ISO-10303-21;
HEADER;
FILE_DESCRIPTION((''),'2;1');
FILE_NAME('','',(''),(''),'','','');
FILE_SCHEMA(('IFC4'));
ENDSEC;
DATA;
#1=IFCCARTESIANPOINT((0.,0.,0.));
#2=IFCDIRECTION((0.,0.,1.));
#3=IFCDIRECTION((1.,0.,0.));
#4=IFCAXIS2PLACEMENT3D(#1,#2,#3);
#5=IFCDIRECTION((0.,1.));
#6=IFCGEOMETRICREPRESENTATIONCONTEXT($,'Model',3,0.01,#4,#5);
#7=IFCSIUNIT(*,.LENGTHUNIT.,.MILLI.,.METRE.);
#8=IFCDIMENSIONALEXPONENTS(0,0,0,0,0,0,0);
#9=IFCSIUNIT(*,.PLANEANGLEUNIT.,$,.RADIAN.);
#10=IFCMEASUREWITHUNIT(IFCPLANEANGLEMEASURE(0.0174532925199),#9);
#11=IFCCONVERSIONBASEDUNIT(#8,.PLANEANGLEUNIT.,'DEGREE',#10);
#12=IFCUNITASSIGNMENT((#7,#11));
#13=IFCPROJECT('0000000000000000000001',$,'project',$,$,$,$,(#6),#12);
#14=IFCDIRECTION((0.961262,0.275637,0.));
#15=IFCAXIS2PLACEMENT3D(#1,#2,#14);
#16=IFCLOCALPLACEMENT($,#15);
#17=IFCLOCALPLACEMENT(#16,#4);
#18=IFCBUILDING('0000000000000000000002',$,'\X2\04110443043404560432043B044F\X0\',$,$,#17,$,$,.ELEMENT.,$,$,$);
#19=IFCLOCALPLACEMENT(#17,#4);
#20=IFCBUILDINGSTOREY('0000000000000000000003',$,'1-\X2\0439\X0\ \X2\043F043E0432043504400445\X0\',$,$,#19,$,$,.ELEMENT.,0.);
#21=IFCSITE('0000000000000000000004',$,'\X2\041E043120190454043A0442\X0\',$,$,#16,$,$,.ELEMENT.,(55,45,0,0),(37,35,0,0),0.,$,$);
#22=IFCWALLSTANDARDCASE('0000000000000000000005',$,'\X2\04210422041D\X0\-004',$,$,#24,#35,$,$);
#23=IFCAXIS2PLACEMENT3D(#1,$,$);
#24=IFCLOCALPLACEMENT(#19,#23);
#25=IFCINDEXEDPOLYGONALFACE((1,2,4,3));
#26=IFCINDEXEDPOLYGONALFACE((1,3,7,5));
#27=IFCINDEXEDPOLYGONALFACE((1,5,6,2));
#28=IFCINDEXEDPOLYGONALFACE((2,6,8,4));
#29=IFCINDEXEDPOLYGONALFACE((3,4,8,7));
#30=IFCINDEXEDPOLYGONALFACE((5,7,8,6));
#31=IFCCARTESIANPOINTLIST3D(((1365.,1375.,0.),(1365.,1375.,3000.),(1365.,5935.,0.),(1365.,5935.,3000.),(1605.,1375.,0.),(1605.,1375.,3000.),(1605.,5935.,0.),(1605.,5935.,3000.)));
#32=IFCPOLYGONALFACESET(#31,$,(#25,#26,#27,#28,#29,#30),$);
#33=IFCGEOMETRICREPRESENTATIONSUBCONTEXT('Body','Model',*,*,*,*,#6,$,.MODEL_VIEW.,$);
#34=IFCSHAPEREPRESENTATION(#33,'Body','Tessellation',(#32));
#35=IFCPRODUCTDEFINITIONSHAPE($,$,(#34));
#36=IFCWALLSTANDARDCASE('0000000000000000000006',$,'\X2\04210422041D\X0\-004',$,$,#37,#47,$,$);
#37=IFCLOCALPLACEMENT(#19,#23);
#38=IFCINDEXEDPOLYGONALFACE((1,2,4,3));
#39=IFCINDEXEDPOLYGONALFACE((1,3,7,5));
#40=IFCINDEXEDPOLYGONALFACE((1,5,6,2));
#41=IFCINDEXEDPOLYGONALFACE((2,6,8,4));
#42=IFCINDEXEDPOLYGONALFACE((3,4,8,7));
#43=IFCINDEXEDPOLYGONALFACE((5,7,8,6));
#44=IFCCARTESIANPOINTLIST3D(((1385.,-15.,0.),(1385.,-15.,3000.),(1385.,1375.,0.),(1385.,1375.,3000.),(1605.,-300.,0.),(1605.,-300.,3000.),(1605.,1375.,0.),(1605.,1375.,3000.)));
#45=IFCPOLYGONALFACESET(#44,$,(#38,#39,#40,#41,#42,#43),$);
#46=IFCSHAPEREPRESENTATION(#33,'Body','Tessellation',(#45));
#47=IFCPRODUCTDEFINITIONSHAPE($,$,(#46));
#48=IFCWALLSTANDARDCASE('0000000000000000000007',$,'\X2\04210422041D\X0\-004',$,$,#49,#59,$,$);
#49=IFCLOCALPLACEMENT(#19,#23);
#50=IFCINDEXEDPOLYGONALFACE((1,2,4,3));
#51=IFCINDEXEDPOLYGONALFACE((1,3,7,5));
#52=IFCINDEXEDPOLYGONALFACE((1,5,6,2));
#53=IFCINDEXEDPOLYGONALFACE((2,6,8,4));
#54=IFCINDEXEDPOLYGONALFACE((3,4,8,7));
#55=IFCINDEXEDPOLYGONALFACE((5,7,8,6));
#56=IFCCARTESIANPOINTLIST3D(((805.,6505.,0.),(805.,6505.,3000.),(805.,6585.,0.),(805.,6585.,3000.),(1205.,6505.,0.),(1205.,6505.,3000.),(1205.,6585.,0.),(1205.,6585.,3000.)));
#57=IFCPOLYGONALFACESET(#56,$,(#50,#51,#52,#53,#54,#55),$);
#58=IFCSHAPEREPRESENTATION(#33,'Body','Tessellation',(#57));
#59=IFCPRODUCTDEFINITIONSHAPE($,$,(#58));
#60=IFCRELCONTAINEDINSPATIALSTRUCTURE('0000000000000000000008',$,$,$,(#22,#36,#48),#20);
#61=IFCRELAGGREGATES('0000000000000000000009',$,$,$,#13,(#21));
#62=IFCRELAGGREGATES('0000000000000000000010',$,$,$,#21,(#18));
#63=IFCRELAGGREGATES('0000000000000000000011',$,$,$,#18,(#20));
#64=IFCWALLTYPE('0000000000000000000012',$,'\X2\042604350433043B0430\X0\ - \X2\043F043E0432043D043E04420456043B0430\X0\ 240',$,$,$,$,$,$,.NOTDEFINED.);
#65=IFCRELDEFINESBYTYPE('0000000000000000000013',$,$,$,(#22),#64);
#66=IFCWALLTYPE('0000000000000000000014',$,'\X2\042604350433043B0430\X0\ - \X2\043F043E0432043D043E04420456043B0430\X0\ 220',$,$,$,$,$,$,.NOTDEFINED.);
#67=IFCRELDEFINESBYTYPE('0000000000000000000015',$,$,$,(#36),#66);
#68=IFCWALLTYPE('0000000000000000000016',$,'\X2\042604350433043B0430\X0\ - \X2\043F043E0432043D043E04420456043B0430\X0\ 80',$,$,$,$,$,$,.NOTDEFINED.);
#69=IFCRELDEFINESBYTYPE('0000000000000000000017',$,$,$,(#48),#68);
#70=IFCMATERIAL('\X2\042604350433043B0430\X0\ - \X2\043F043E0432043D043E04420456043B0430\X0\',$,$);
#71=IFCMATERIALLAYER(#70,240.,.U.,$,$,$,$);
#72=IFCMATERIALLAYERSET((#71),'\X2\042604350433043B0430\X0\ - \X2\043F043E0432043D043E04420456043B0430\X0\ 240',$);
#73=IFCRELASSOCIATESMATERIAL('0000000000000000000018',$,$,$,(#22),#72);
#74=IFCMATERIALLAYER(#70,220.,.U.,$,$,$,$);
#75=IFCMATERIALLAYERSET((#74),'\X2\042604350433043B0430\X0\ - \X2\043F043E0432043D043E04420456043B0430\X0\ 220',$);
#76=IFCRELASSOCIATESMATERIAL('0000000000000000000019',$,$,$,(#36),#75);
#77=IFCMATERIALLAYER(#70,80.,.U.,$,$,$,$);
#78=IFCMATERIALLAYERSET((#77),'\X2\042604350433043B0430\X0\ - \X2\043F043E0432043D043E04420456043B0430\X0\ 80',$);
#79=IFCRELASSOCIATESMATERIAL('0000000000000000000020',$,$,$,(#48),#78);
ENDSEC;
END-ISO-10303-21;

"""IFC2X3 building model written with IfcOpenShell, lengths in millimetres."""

from ifc_helpers import new_model, entity, si_unit, converted_unit, direction, frame, origin_with_axes, place, context, subcontext, project, spatial, polyline, outline, extrude, material, layer, layer_set, layer_usage, type_object, element, save


model = new_model("IFC2X3")

# Units and contexts
model_context = context("Model", 3, precision=0.01, world=origin_with_axes(), true_north=direction((0.0, 1.0)))
body_context = subcontext(model_context, "Body", "Model", "MODEL_VIEW")
ifc_project = project(units=[si_unit("LENGTHUNIT", "METRE", prefix="MILLI"), converted_unit("PLANEANGLEUNIT", "DEGREE", entity("IfcPlaneAngleMeasure", 0.0174532925199), si_unit("PLANEANGLEUNIT", "RADIAN"), dimensions=[0, 0, 0, 0, 0, 0, 0])], contexts=[model_context])

# Site, building, storey
site_placement = place(None, frame((0.0, 0.0, 0.0), z_axis=(0.0, 0.0, 1.0), x_axis=(0.961262, 0.275637, 0.0)))
site = spatial("IfcSite", under=ifc_project, at=site_placement, Name="Об’єкт", CompositionType="ELEMENT", RefLatitude=(55, 45, 0, 0), RefLongitude=(37, 35, 0, 0), RefElevation=0.0)
building_placement = place(site_placement, origin_with_axes())
building = spatial("IfcBuilding", under=site, at=building_placement, Name="Будівля", CompositionType="ELEMENT")
storey_placement = place(building_placement, origin_with_axes())
storey = spatial("IfcBuildingStorey", under=building, at=storey_placement, Name="1-й поверх", CompositionType="ELEMENT", Elevation=0.0)

# Walls
ifc_material_1 = material(Name="Цегла - повнотіла")
ifc_layer_1 = layer(ifc_material_1, 240.0, ventilated="UNKNOWN")
ifc_layer_set_1 = layer_set([ifc_layer_1], Name="Цегла - повнотіла 240")
ifc_layer_usage_1 = layer_usage(ifc_layer_set_1, "AXIS2", "POSITIVE", 0.0)
wall_type_1 = type_object("IfcWallType", Name="Цегла - повнотіла 240", PredefinedType="NOTDEFINED")
wall_1_placement = place(storey_placement, frame((1605.0, 1375.0, 0.0), z_axis=(0.0, 0.0, 1.0), x_axis=(0.0, 1.0, 0.0)))
element("IfcWallStandardCase", 1, at=wall_1_placement, inside=storey, type_object=wall_type_1, material=ifc_layer_usage_1, Name="СТН-004", context=body_context, shape_type="SweptSolid", body=[
    extrude(outline(polyline([(0.0, 0.0), (4560.0, 0.0), (4560.0, 240.0), (0.0, 240.0), (0.0, 0.0)])), origin_with_axes(), (0.0, 0.0, 1.0), 3000.0),
])
ifc_layer_2 = layer(ifc_material_1, 220.0, ventilated="UNKNOWN")
ifc_layer_set_2 = layer_set([ifc_layer_2], Name="Цегла - повнотіла 220")
ifc_layer_usage_2 = layer_usage(ifc_layer_set_2, "AXIS2", "POSITIVE", 0.0)
wall_type_2 = type_object("IfcWallType", Name="Цегла - повнотіла 220", PredefinedType="NOTDEFINED")
wall_2_placement = place(storey_placement, frame((1605.0, -300.0, 0.0), z_axis=(0.0, 0.0, 1.0), x_axis=(0.0, 1.0, 0.0)))
element("IfcWallStandardCase", 2, at=wall_2_placement, inside=storey, type_object=wall_type_2, material=ifc_layer_usage_2, Name="СТН-004", context=body_context, shape_type="SweptSolid", body=[
    extrude(outline(polyline([(0.0, 0.0), (1675.0, 0.0), (1675.0, 220.0), (285.0, 220.0), (0.0, 0.0)])), origin_with_axes(), (0.0, 0.0, 1.0), 3000.0),
])
ifc_layer_3 = layer(ifc_material_1, 80.0, ventilated="UNKNOWN")
ifc_layer_set_3 = layer_set([ifc_layer_3], Name="Цегла - повнотіла 80")
ifc_layer_usage_3 = layer_usage(ifc_layer_set_3, "AXIS2", "POSITIVE", -80.0)
wall_type_3 = type_object("IfcWallType", Name="Цегла - повнотіла 80", PredefinedType="NOTDEFINED")
wall_3_placement = place(storey_placement, frame((805.0, 6585.0, 0.0), z_axis=(0.0, 0.0, 1.0), x_axis=(1.0, 0.0, 0.0)))
element("IfcWallStandardCase", 3, at=wall_3_placement, inside=storey, type_object=wall_type_3, material=ifc_layer_usage_3, Name="СТН-004", context=body_context, shape_type="SweptSolid", body=[
    extrude(outline(polyline([(0.0, -80.0), (400.0, -80.0), (400.0, 0.0), (0.0, 0.0), (0.0, -80.0)])), origin_with_axes(), (0.0, 0.0, 1.0), 3000.0),
])

save(model, "model.ifc")
